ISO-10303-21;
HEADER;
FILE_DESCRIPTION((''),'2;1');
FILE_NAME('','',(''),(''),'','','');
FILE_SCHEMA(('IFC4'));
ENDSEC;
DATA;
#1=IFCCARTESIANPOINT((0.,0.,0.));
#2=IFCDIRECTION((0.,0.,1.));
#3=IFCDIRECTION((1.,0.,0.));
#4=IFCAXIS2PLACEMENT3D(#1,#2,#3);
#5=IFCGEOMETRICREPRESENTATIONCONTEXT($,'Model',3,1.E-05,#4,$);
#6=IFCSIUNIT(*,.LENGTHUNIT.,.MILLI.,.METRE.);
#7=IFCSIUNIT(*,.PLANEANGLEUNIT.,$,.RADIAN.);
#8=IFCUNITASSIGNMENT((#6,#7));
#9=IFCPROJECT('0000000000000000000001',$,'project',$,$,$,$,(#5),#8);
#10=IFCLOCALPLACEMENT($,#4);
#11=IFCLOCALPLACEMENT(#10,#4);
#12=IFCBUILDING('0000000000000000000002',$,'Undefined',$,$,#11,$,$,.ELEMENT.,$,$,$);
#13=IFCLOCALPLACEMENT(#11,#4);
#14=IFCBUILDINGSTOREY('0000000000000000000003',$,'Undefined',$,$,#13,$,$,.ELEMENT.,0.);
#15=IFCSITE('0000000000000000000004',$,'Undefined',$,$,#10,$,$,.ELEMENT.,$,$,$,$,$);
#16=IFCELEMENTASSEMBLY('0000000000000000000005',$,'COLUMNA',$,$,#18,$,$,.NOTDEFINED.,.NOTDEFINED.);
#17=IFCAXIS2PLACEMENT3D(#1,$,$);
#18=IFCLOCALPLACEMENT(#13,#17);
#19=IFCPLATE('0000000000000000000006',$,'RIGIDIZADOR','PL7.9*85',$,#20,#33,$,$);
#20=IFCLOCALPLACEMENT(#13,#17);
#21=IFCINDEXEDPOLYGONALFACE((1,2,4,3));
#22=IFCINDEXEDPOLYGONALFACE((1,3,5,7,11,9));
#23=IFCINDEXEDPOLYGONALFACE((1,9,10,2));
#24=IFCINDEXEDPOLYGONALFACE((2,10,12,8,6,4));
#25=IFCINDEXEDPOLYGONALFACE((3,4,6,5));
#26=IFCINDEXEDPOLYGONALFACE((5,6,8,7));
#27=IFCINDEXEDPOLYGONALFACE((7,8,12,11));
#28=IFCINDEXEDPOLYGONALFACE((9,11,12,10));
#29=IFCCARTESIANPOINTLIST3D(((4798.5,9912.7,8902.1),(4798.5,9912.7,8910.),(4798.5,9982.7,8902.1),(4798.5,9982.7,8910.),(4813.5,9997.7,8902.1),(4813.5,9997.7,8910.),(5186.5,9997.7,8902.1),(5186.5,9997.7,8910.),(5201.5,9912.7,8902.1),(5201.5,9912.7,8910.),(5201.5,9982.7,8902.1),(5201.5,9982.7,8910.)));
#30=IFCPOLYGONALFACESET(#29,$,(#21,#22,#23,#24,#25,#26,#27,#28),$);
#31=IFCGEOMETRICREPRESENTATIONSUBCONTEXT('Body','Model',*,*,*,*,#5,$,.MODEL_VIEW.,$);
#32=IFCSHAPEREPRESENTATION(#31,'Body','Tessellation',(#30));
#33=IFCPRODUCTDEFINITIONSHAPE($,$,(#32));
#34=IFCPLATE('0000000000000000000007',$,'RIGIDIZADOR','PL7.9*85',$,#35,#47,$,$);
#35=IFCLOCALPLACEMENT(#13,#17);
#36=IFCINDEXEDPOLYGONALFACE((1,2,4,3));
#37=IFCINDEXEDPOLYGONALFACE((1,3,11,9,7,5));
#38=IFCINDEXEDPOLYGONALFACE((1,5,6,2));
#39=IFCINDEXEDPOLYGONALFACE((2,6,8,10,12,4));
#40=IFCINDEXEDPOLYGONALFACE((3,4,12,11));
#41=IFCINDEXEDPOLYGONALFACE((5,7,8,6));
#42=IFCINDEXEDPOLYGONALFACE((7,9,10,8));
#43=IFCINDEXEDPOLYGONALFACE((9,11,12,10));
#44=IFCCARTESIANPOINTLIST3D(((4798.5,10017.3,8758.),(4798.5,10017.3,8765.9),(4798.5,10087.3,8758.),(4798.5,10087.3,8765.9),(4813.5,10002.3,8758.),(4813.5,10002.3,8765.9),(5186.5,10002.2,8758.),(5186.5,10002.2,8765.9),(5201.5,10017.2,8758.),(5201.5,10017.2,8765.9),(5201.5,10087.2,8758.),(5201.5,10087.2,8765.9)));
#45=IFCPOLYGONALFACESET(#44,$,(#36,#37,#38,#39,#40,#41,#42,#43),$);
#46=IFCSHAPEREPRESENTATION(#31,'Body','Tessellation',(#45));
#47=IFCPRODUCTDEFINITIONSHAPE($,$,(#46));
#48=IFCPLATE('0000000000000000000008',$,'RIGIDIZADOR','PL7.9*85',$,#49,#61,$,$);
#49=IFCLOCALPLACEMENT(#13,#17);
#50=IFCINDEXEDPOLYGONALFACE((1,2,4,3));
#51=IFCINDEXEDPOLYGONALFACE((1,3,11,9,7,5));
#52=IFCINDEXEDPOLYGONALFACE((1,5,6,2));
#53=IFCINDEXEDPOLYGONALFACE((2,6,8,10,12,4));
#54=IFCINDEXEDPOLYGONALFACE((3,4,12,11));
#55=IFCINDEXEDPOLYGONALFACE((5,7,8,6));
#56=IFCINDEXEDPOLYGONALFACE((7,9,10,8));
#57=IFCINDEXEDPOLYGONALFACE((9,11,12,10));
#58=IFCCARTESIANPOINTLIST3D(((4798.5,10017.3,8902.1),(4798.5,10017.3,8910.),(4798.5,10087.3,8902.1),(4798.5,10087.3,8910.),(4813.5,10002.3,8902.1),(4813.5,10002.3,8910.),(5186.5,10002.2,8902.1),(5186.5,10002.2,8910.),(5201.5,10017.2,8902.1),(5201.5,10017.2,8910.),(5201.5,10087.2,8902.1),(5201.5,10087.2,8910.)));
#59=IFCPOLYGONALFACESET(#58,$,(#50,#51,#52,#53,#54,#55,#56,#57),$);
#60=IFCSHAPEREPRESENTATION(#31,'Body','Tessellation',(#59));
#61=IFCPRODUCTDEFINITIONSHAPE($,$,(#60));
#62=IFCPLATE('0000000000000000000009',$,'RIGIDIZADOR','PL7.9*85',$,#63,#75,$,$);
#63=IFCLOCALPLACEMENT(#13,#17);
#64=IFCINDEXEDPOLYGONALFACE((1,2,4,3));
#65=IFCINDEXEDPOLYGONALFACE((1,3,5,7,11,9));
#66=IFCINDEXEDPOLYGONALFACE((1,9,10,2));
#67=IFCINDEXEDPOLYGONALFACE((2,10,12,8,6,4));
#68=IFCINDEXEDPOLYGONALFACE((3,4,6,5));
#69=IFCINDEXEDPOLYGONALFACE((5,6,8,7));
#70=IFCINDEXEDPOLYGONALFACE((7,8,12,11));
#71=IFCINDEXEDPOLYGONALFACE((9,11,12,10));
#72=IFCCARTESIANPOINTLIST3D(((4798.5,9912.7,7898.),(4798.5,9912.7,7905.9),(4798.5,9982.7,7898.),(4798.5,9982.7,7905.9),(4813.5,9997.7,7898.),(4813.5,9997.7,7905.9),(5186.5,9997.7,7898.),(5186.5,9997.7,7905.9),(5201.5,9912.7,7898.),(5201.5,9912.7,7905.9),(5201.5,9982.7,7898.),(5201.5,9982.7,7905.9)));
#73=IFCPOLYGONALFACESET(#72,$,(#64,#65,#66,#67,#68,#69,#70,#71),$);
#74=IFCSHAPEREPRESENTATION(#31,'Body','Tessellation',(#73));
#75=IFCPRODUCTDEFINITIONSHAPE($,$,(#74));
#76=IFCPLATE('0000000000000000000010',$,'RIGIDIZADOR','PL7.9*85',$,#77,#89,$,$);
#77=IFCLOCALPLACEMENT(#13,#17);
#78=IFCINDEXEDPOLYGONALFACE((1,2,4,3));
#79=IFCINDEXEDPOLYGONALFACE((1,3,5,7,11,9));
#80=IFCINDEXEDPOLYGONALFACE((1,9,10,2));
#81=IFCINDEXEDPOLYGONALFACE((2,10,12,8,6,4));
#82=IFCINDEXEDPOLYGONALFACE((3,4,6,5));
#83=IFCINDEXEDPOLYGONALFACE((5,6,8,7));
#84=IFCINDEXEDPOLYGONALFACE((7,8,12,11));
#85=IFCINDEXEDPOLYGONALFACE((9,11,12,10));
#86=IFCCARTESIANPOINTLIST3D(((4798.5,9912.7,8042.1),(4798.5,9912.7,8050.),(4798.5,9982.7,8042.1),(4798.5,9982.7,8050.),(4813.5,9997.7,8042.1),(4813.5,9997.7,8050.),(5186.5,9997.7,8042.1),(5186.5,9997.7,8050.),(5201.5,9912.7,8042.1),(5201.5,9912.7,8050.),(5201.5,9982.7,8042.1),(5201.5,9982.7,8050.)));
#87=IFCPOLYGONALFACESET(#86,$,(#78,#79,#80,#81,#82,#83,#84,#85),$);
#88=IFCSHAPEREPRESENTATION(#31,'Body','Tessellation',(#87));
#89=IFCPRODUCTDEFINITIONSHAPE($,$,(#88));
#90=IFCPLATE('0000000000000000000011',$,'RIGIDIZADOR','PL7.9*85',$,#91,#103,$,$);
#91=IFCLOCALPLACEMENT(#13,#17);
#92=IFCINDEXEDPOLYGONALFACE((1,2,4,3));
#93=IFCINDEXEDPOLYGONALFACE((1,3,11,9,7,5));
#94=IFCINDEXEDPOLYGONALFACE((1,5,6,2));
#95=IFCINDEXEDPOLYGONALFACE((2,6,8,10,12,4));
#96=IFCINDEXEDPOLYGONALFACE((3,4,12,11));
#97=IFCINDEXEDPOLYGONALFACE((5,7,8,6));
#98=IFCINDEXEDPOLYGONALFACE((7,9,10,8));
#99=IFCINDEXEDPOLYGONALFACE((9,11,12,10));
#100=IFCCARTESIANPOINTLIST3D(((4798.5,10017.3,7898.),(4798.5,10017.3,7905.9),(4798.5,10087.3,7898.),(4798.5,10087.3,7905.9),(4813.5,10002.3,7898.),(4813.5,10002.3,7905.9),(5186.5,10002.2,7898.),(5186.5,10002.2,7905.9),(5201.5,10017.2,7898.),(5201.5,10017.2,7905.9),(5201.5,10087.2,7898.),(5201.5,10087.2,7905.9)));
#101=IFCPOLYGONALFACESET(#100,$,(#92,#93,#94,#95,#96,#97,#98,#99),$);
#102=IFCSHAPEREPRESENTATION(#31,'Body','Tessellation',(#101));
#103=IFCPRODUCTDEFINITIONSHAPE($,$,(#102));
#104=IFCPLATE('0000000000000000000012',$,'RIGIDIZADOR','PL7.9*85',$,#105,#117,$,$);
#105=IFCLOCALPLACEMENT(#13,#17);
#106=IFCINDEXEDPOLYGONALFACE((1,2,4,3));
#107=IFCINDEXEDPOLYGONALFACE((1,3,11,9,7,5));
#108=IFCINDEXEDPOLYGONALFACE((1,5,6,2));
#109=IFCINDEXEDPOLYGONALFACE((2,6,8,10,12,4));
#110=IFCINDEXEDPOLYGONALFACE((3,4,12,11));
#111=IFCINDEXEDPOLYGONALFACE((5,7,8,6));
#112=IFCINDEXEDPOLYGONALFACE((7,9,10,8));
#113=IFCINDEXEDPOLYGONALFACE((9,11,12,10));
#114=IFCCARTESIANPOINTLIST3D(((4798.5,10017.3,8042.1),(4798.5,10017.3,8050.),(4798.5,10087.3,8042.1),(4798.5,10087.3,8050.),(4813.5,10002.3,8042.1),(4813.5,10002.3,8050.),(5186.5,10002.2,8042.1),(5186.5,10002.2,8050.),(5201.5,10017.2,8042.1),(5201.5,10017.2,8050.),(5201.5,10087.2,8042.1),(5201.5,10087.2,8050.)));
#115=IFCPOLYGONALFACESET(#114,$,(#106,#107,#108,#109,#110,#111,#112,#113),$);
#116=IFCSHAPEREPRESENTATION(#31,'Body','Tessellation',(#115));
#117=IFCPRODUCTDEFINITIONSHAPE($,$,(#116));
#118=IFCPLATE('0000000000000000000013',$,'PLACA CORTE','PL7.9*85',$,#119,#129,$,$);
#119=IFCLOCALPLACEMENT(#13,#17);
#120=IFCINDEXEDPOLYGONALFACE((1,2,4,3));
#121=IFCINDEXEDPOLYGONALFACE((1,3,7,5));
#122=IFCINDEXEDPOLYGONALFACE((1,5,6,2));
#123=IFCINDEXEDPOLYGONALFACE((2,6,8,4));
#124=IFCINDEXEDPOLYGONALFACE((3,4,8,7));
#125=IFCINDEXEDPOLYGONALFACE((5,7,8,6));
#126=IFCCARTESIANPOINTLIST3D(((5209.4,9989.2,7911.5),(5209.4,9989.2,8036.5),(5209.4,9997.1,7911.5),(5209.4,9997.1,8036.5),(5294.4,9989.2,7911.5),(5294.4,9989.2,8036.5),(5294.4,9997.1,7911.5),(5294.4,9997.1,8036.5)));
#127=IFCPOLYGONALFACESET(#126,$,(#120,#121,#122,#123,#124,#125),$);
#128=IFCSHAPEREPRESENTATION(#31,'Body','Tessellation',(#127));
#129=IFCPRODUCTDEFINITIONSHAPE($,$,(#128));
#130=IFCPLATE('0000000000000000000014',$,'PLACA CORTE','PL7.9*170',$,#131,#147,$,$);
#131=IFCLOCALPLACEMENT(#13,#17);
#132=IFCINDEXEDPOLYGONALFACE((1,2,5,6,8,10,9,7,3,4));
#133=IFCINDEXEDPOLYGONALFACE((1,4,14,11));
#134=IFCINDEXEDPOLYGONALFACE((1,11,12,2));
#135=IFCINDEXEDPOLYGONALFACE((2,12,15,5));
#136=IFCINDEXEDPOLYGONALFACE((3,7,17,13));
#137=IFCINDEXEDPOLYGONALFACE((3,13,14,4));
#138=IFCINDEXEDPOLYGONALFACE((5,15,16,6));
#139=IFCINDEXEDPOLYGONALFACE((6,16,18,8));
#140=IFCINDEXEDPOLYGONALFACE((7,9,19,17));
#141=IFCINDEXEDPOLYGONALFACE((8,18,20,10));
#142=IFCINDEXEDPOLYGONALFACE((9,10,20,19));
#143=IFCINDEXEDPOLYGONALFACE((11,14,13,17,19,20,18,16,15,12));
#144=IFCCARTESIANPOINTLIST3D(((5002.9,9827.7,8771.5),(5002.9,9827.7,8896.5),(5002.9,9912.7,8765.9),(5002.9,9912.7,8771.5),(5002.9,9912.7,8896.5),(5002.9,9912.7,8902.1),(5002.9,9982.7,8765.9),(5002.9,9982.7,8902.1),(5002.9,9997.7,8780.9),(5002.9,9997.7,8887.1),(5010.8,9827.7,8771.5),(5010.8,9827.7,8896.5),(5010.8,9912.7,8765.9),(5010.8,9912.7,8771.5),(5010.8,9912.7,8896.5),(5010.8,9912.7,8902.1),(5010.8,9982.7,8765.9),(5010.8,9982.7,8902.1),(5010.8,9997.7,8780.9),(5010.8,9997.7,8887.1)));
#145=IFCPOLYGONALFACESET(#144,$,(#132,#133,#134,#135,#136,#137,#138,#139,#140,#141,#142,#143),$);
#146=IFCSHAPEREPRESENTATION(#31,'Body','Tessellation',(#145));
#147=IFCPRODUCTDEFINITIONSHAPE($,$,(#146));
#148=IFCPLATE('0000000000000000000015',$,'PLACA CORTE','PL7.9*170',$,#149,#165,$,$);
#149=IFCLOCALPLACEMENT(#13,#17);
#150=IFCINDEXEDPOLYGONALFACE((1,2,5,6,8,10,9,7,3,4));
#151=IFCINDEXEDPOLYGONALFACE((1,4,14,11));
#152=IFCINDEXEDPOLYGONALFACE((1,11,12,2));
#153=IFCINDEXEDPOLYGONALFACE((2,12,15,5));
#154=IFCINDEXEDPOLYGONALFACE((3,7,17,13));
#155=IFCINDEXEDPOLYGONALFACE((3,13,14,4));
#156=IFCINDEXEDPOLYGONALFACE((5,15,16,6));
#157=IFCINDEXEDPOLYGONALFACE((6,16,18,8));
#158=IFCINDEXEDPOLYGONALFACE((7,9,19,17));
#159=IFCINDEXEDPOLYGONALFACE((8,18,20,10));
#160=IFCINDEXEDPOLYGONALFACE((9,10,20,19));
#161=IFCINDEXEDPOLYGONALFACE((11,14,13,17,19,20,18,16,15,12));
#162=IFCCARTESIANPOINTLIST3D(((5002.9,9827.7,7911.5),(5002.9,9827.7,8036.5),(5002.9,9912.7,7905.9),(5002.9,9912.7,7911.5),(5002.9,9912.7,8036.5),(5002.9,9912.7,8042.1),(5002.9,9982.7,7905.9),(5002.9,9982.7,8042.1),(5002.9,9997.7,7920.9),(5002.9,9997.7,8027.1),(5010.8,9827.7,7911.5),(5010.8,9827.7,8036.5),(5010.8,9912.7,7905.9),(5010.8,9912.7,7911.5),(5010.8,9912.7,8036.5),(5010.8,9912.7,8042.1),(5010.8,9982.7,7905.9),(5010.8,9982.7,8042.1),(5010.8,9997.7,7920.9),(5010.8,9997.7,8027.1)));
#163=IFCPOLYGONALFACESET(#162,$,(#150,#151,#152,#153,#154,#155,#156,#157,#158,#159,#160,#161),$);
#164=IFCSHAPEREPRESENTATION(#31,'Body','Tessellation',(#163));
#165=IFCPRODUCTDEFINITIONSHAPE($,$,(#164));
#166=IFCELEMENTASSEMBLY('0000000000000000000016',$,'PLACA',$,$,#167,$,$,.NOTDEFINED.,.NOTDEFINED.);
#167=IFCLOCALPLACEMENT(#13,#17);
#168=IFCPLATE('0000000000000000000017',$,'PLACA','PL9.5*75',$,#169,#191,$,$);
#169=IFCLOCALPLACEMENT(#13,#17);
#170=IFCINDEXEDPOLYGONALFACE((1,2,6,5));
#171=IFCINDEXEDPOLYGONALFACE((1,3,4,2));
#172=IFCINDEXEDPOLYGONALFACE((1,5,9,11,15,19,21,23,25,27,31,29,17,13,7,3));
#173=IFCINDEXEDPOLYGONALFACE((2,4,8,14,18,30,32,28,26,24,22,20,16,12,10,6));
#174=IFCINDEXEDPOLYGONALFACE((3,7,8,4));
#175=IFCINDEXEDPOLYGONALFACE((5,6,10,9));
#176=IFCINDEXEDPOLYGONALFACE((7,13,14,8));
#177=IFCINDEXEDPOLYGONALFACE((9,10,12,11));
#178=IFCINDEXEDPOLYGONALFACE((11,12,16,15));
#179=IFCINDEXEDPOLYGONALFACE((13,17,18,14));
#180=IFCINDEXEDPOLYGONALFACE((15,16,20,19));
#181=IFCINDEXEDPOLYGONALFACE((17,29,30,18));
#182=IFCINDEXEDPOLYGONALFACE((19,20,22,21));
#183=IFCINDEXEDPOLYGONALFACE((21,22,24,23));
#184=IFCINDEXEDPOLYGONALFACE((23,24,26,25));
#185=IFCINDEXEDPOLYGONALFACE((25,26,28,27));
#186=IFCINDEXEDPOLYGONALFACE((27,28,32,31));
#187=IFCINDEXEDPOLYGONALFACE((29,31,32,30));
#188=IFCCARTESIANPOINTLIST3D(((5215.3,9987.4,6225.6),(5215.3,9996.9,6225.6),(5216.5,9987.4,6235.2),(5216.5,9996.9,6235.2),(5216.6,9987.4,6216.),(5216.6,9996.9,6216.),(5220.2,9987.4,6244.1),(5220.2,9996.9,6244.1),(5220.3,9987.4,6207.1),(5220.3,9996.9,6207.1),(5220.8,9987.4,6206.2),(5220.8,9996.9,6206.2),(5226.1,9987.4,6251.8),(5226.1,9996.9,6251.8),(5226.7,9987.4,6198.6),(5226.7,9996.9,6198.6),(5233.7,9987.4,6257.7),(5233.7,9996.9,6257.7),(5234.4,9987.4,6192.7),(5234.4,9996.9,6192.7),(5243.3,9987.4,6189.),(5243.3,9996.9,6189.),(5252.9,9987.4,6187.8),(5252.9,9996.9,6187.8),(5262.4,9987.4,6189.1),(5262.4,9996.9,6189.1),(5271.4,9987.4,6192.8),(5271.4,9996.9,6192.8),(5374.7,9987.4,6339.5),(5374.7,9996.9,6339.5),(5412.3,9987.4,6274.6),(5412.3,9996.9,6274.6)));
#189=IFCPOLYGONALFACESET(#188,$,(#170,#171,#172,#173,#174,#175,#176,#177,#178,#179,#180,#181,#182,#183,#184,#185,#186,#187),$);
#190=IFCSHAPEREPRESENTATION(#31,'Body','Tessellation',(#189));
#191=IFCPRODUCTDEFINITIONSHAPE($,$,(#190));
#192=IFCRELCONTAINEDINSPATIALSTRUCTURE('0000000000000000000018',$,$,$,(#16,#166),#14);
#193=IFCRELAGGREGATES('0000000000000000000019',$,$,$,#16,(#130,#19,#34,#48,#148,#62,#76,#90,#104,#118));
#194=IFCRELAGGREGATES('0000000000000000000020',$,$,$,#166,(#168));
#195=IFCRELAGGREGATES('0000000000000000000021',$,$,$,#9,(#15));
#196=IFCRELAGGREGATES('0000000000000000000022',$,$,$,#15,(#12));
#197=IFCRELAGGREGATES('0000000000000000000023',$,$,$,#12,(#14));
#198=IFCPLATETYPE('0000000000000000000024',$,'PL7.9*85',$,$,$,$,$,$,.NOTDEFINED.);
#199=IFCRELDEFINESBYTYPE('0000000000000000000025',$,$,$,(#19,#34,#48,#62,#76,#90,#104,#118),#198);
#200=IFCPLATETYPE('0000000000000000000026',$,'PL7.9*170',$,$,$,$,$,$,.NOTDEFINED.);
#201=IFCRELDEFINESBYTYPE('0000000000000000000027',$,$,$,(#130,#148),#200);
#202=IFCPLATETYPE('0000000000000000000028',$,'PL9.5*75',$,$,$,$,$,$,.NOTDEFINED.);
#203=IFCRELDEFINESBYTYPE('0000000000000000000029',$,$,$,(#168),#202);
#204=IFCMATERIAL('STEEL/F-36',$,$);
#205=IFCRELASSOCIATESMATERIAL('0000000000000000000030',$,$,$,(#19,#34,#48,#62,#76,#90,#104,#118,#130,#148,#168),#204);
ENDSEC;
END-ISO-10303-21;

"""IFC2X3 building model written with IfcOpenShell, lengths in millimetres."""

from ifc_helpers import new_model, si_unit, frame, frame_2d, origin_with_axes, place, context, subcontext, project, spatial, polyline, circle_curve, parameter, trimmed, segment, composite_curve, outline, extrude, material, type_object, element, aggregate, save


model = new_model("IFC2X3")

# Units and contexts
model_context = context("Model", 3, precision=1e-05, world=origin_with_axes())
body_context = subcontext(model_context, "Body", "Model", "MODEL_VIEW")
ifc_project = project(units=[si_unit("LENGTHUNIT", "METRE", prefix="MILLI"), si_unit("PLANEANGLEUNIT", "RADIAN")], contexts=[model_context])

# Site, building, storey
site_placement = place(None, origin_with_axes())
site = spatial("IfcSite", under=ifc_project, at=site_placement, Name="Undefined", CompositionType="ELEMENT")
building_placement = place(site_placement, origin_with_axes())
building = spatial("IfcBuilding", under=site, at=building_placement, Name="Undefined", CompositionType="ELEMENT")
storey_placement = place(building_placement, origin_with_axes())
storey = spatial("IfcBuildingStorey", under=building, at=storey_placement, Name="Undefined", CompositionType="ELEMENT", Elevation=0.0)

# Element assembly
assembly_1_placement = place(storey_placement, origin_with_axes())
assembly_1 = element("IfcElementAssembly", 1, at=assembly_1_placement, inside=storey, Name="COLUMNA", AssemblyPlace="NOTDEFINED", PredefinedType="NOTDEFINED")

# Shared definitions
ifc_material_1 = material(Name="STEEL/F-36")

# Plates
plate_type_1 = type_object("IfcPlateType", Name="PL7.9*85", PredefinedType="NOTDEFINED")
plate_1_placement = place(assembly_1_placement, frame((5201.5, 9997.7, 8906.0), z_axis=(0.0, 0.0, -1.0), x_axis=(0.0, -1.0, 0.0)))
plate_1 = element("IfcPlate", 2, at=plate_1_placement, type_object=plate_type_1, material=ifc_material_1, Name="RIGIDIZADOR", Description="PL7.9*85", context=body_context, shape_type="SweptSolid", body=[
    extrude(outline(polyline([(0.0, 15.0), (15.0, 0.0), (85.0, 0.0), (85.0, 403.0), (15.0, 403.0), (0.0, 388.0), (0.0, 15.0)])), frame((0.0, 0.0, -4.0), z_axis=(0.0, 0.0, 1.0), x_axis=(1.0, 0.0, 0.0)), (0.0, 0.0, 1.0), 7.9),
])
plate_2_placement = place(assembly_1_placement, frame((5201.5, 10002.2, 8761.9), z_axis=(0.0, 0.0, 1.0), x_axis=(0.0, 1.0, 0.0)))
plate_2 = element("IfcPlate", 3, at=plate_2_placement, type_object=plate_type_1, material=ifc_material_1, Name="RIGIDIZADOR", Description="PL7.9*85", context=body_context, shape_type="SweptSolid", body=[
    extrude(outline(polyline([(0.0, 15.0), (15.0, 0.0), (85.0, 0.0), (85.0, 403.0), (15.0, 403.0), (0.0, 388.0), (0.0, 15.0)])), frame((0.0, 0.0, -4.0), z_axis=(0.0, 0.0, 1.0), x_axis=(1.0, 0.0, 0.0)), (0.0, 0.0, 1.0), 7.9),
])
plate_3_placement = place(assembly_1_placement, frame((5201.5, 10002.2, 8906.0), z_axis=(0.0, 0.0, 1.0), x_axis=(0.0, 1.0, 0.0)))
plate_3 = element("IfcPlate", 4, at=plate_3_placement, type_object=plate_type_1, material=ifc_material_1, Name="RIGIDIZADOR", Description="PL7.9*85", context=body_context, shape_type="SweptSolid", body=[
    extrude(outline(polyline([(0.0, 15.0), (15.0, 0.0), (85.0, 0.0), (85.0, 403.0), (15.0, 403.0), (0.0, 388.0), (0.0, 15.0)])), frame((0.0, 0.0, -4.0), z_axis=(0.0, 0.0, 1.0), x_axis=(1.0, 0.0, 0.0)), (0.0, 0.0, 1.0), 7.9),
])
plate_4_placement = place(assembly_1_placement, frame((5201.5, 9997.7, 7902.0), z_axis=(0.0, 0.0, -1.0), x_axis=(0.0, -1.0, 0.0)))
plate_4 = element("IfcPlate", 5, at=plate_4_placement, type_object=plate_type_1, material=ifc_material_1, Name="RIGIDIZADOR", Description="PL7.9*85", context=body_context, shape_type="SweptSolid", body=[
    extrude(outline(polyline([(0.0, 15.0), (15.0, 0.0), (85.0, 0.0), (85.0, 403.0), (15.0, 403.0), (0.0, 388.0), (0.0, 15.0)])), frame((0.0, 0.0, -4.0), z_axis=(0.0, 0.0, 1.0), x_axis=(1.0, 0.0, 0.0)), (0.0, 0.0, 1.0), 7.9),
])
plate_5_placement = place(assembly_1_placement, frame((5201.5, 9997.7, 8046.1), z_axis=(0.0, 0.0, -1.0), x_axis=(0.0, -1.0, 0.0)))
plate_5 = element("IfcPlate", 6, at=plate_5_placement, type_object=plate_type_1, material=ifc_material_1, Name="RIGIDIZADOR", Description="PL7.9*85", context=body_context, shape_type="SweptSolid", body=[
    extrude(outline(polyline([(0.0, 15.0), (15.0, 0.0), (85.0, 0.0), (85.0, 403.0), (15.0, 403.0), (0.0, 388.0), (0.0, 15.0)])), frame((0.0, 0.0, -4.0), z_axis=(0.0, 0.0, 1.0), x_axis=(1.0, 0.0, 0.0)), (0.0, 0.0, 1.0), 7.9),
])
plate_6_placement = place(assembly_1_placement, frame((5201.5, 10002.2, 7902.0), z_axis=(0.0, 0.0, 1.0), x_axis=(0.0, 1.0, 0.0)))
plate_6 = element("IfcPlate", 7, at=plate_6_placement, type_object=plate_type_1, material=ifc_material_1, Name="RIGIDIZADOR", Description="PL7.9*85", context=body_context, shape_type="SweptSolid", body=[
    extrude(outline(polyline([(0.0, 15.0), (15.0, 0.0), (85.0, 0.0), (85.0, 403.0), (15.0, 403.0), (0.0, 388.0), (0.0, 15.0)])), frame((0.0, 0.0, -4.0), z_axis=(0.0, 0.0, 1.0), x_axis=(1.0, 0.0, 0.0)), (0.0, 0.0, 1.0), 7.9),
])
plate_7_placement = place(assembly_1_placement, frame((5201.5, 10002.2, 8046.1), z_axis=(0.0, 0.0, 1.0), x_axis=(0.0, 1.0, 0.0)))
plate_7 = element("IfcPlate", 8, at=plate_7_placement, type_object=plate_type_1, material=ifc_material_1, Name="RIGIDIZADOR", Description="PL7.9*85", context=body_context, shape_type="SweptSolid", body=[
    extrude(outline(polyline([(0.0, 15.0), (15.0, 0.0), (85.0, 0.0), (85.0, 403.0), (15.0, 403.0), (0.0, 388.0), (0.0, 15.0)])), frame((0.0, 0.0, -4.0), z_axis=(0.0, 0.0, 1.0), x_axis=(1.0, 0.0, 0.0)), (0.0, 0.0, 1.0), 7.9),
])
plate_8_placement = place(assembly_1_placement, frame((5209.4, 9993.1, 7911.5), z_axis=(0.000002, -1.0, 0.0), x_axis=(1.0, 0.000003, 0.0)))
plate_8 = element("IfcPlate", 9, at=plate_8_placement, type_object=plate_type_1, material=ifc_material_1, Name="PLACA CORTE", Description="PL7.9*85", context=body_context, shape_type="SweptSolid", body=[
    extrude(outline(polyline([(0.0, 0.0), (85.0, 0.0), (85.0, 125.0), (0.0, 125.0), (0.0, 0.0)])), frame((0.0, 0.0, -4.0), z_axis=(0.0, 0.0, 1.0), x_axis=(1.0, 0.0, 0.0)), (0.0, 0.0, 1.0), 7.9),
])
plate_type_2 = type_object("IfcPlateType", Name="PL7.9*170", PredefinedType="NOTDEFINED")
plate_9_placement = place(assembly_1_placement, frame((5006.8, 9997.7, 8902.1), z_axis=(-1.0, 0.0, 0.0), x_axis=(0.0, 0.0, -1.0)))
plate_9 = element("IfcPlate", 10, at=plate_9_placement, type_object=plate_type_2, material=ifc_material_1, Name="PLACA CORTE", Description="PL7.9*170", context=body_context, shape_type="SweptSolid", body=[
    extrude(outline(polyline([(0.0, 15.0), (15.0, 0.0), (121.2, 0.0), (136.2, 15.0), (136.2, 85.0), (130.6, 85.0), (130.6, 170.0), (5.6, 170.0), (5.6, 85.0), (0.0, 85.0), (0.0, 15.0)])), frame((0.0, 0.0, -4.0), z_axis=(0.0, 0.0, 1.0), x_axis=(1.0, 0.0, 0.0)), (0.0, 0.0, 1.0), 7.9),
])
plate_10_placement = place(assembly_1_placement, frame((5006.8, 9997.7, 8042.1), z_axis=(-1.0, 0.0, 0.0), x_axis=(0.0, 0.0, -1.0)))
plate_10 = element("IfcPlate", 11, at=plate_10_placement, type_object=plate_type_2, material=ifc_material_1, Name="PLACA CORTE", Description="PL7.9*170", context=body_context, shape_type="SweptSolid", body=[
    extrude(outline(polyline([(0.0, 15.0), (15.0, 0.0), (121.2, 0.0), (136.2, 15.0), (136.2, 85.0), (130.6, 85.0), (130.6, 170.0), (5.6, 170.0), (5.6, 85.0), (0.0, 85.0), (0.0, 15.0)])), frame((0.0, 0.0, -4.0), z_axis=(0.0, 0.0, 1.0), x_axis=(1.0, 0.0, 0.0)), (0.0, 0.0, 1.0), 7.9),
])
aggregate(assembly_1, [plate_9, plate_1, plate_2, plate_3, plate_10, plate_4, plate_5, plate_6, plate_7, plate_8])

# Element assembly, plate
assembly_2_placement = place(storey_placement, origin_with_axes())
assembly_2 = element("IfcElementAssembly", 12, at=assembly_2_placement, inside=storey, Name="PLACA", AssemblyPlace="NOTDEFINED", PredefinedType="NOTDEFINED")
plate_type_3 = type_object("IfcPlateType", Name="PL9.5*75", PredefinedType="NOTDEFINED")
plate_11_placement = place(assembly_2_placement, frame((5201.7, 9992.1, 6239.1), z_axis=(0.0, -1.0, 0.0), x_axis=(0.501976, 0.0, -0.864882)))
plate_11 = element("IfcPlate", 13, at=plate_11_placement, type_object=plate_type_3, material=ifc_material_1, Name="PLACA", Description="PL9.5*75", context=body_context, shape_type="SweptSolid", body=[
    extrude(outline(composite_curve([segment(trimmed(circle_curve(frame_2d((37.0, 37.0), x_axis=(-1.0, 0.0)), 37.0), [parameter(0.0)], [parameter(1.570796)], True, "PARAMETER"), True, "CONTINUOUS"), segment(polyline([(37.0, 0.0), (38.0, 0.0)]), True, "CONTINUOUS"), segment(trimmed(circle_curve(frame_2d((38.0, 37.0), x_axis=(0.0, -1.0)), 37.0), [parameter(0.0)], [parameter(1.570797)], True, "PARAMETER"), True, "CONTINUOUS"), segment(polyline([(75.0, 37.0), (75.0, 200.0), (0.0, 200.0), (0.0, 37.0)]), True, "CONTINUOUS")], self_intersect=True)), frame((0.0, 0.0, -4.8), z_axis=(0.0, 0.0, 1.0), x_axis=(1.0, 0.0, 0.0)), (0.0, 0.0, 1.0), 9.5),
])
aggregate(assembly_2, [plate_11])

save(model, "model.ifc")
